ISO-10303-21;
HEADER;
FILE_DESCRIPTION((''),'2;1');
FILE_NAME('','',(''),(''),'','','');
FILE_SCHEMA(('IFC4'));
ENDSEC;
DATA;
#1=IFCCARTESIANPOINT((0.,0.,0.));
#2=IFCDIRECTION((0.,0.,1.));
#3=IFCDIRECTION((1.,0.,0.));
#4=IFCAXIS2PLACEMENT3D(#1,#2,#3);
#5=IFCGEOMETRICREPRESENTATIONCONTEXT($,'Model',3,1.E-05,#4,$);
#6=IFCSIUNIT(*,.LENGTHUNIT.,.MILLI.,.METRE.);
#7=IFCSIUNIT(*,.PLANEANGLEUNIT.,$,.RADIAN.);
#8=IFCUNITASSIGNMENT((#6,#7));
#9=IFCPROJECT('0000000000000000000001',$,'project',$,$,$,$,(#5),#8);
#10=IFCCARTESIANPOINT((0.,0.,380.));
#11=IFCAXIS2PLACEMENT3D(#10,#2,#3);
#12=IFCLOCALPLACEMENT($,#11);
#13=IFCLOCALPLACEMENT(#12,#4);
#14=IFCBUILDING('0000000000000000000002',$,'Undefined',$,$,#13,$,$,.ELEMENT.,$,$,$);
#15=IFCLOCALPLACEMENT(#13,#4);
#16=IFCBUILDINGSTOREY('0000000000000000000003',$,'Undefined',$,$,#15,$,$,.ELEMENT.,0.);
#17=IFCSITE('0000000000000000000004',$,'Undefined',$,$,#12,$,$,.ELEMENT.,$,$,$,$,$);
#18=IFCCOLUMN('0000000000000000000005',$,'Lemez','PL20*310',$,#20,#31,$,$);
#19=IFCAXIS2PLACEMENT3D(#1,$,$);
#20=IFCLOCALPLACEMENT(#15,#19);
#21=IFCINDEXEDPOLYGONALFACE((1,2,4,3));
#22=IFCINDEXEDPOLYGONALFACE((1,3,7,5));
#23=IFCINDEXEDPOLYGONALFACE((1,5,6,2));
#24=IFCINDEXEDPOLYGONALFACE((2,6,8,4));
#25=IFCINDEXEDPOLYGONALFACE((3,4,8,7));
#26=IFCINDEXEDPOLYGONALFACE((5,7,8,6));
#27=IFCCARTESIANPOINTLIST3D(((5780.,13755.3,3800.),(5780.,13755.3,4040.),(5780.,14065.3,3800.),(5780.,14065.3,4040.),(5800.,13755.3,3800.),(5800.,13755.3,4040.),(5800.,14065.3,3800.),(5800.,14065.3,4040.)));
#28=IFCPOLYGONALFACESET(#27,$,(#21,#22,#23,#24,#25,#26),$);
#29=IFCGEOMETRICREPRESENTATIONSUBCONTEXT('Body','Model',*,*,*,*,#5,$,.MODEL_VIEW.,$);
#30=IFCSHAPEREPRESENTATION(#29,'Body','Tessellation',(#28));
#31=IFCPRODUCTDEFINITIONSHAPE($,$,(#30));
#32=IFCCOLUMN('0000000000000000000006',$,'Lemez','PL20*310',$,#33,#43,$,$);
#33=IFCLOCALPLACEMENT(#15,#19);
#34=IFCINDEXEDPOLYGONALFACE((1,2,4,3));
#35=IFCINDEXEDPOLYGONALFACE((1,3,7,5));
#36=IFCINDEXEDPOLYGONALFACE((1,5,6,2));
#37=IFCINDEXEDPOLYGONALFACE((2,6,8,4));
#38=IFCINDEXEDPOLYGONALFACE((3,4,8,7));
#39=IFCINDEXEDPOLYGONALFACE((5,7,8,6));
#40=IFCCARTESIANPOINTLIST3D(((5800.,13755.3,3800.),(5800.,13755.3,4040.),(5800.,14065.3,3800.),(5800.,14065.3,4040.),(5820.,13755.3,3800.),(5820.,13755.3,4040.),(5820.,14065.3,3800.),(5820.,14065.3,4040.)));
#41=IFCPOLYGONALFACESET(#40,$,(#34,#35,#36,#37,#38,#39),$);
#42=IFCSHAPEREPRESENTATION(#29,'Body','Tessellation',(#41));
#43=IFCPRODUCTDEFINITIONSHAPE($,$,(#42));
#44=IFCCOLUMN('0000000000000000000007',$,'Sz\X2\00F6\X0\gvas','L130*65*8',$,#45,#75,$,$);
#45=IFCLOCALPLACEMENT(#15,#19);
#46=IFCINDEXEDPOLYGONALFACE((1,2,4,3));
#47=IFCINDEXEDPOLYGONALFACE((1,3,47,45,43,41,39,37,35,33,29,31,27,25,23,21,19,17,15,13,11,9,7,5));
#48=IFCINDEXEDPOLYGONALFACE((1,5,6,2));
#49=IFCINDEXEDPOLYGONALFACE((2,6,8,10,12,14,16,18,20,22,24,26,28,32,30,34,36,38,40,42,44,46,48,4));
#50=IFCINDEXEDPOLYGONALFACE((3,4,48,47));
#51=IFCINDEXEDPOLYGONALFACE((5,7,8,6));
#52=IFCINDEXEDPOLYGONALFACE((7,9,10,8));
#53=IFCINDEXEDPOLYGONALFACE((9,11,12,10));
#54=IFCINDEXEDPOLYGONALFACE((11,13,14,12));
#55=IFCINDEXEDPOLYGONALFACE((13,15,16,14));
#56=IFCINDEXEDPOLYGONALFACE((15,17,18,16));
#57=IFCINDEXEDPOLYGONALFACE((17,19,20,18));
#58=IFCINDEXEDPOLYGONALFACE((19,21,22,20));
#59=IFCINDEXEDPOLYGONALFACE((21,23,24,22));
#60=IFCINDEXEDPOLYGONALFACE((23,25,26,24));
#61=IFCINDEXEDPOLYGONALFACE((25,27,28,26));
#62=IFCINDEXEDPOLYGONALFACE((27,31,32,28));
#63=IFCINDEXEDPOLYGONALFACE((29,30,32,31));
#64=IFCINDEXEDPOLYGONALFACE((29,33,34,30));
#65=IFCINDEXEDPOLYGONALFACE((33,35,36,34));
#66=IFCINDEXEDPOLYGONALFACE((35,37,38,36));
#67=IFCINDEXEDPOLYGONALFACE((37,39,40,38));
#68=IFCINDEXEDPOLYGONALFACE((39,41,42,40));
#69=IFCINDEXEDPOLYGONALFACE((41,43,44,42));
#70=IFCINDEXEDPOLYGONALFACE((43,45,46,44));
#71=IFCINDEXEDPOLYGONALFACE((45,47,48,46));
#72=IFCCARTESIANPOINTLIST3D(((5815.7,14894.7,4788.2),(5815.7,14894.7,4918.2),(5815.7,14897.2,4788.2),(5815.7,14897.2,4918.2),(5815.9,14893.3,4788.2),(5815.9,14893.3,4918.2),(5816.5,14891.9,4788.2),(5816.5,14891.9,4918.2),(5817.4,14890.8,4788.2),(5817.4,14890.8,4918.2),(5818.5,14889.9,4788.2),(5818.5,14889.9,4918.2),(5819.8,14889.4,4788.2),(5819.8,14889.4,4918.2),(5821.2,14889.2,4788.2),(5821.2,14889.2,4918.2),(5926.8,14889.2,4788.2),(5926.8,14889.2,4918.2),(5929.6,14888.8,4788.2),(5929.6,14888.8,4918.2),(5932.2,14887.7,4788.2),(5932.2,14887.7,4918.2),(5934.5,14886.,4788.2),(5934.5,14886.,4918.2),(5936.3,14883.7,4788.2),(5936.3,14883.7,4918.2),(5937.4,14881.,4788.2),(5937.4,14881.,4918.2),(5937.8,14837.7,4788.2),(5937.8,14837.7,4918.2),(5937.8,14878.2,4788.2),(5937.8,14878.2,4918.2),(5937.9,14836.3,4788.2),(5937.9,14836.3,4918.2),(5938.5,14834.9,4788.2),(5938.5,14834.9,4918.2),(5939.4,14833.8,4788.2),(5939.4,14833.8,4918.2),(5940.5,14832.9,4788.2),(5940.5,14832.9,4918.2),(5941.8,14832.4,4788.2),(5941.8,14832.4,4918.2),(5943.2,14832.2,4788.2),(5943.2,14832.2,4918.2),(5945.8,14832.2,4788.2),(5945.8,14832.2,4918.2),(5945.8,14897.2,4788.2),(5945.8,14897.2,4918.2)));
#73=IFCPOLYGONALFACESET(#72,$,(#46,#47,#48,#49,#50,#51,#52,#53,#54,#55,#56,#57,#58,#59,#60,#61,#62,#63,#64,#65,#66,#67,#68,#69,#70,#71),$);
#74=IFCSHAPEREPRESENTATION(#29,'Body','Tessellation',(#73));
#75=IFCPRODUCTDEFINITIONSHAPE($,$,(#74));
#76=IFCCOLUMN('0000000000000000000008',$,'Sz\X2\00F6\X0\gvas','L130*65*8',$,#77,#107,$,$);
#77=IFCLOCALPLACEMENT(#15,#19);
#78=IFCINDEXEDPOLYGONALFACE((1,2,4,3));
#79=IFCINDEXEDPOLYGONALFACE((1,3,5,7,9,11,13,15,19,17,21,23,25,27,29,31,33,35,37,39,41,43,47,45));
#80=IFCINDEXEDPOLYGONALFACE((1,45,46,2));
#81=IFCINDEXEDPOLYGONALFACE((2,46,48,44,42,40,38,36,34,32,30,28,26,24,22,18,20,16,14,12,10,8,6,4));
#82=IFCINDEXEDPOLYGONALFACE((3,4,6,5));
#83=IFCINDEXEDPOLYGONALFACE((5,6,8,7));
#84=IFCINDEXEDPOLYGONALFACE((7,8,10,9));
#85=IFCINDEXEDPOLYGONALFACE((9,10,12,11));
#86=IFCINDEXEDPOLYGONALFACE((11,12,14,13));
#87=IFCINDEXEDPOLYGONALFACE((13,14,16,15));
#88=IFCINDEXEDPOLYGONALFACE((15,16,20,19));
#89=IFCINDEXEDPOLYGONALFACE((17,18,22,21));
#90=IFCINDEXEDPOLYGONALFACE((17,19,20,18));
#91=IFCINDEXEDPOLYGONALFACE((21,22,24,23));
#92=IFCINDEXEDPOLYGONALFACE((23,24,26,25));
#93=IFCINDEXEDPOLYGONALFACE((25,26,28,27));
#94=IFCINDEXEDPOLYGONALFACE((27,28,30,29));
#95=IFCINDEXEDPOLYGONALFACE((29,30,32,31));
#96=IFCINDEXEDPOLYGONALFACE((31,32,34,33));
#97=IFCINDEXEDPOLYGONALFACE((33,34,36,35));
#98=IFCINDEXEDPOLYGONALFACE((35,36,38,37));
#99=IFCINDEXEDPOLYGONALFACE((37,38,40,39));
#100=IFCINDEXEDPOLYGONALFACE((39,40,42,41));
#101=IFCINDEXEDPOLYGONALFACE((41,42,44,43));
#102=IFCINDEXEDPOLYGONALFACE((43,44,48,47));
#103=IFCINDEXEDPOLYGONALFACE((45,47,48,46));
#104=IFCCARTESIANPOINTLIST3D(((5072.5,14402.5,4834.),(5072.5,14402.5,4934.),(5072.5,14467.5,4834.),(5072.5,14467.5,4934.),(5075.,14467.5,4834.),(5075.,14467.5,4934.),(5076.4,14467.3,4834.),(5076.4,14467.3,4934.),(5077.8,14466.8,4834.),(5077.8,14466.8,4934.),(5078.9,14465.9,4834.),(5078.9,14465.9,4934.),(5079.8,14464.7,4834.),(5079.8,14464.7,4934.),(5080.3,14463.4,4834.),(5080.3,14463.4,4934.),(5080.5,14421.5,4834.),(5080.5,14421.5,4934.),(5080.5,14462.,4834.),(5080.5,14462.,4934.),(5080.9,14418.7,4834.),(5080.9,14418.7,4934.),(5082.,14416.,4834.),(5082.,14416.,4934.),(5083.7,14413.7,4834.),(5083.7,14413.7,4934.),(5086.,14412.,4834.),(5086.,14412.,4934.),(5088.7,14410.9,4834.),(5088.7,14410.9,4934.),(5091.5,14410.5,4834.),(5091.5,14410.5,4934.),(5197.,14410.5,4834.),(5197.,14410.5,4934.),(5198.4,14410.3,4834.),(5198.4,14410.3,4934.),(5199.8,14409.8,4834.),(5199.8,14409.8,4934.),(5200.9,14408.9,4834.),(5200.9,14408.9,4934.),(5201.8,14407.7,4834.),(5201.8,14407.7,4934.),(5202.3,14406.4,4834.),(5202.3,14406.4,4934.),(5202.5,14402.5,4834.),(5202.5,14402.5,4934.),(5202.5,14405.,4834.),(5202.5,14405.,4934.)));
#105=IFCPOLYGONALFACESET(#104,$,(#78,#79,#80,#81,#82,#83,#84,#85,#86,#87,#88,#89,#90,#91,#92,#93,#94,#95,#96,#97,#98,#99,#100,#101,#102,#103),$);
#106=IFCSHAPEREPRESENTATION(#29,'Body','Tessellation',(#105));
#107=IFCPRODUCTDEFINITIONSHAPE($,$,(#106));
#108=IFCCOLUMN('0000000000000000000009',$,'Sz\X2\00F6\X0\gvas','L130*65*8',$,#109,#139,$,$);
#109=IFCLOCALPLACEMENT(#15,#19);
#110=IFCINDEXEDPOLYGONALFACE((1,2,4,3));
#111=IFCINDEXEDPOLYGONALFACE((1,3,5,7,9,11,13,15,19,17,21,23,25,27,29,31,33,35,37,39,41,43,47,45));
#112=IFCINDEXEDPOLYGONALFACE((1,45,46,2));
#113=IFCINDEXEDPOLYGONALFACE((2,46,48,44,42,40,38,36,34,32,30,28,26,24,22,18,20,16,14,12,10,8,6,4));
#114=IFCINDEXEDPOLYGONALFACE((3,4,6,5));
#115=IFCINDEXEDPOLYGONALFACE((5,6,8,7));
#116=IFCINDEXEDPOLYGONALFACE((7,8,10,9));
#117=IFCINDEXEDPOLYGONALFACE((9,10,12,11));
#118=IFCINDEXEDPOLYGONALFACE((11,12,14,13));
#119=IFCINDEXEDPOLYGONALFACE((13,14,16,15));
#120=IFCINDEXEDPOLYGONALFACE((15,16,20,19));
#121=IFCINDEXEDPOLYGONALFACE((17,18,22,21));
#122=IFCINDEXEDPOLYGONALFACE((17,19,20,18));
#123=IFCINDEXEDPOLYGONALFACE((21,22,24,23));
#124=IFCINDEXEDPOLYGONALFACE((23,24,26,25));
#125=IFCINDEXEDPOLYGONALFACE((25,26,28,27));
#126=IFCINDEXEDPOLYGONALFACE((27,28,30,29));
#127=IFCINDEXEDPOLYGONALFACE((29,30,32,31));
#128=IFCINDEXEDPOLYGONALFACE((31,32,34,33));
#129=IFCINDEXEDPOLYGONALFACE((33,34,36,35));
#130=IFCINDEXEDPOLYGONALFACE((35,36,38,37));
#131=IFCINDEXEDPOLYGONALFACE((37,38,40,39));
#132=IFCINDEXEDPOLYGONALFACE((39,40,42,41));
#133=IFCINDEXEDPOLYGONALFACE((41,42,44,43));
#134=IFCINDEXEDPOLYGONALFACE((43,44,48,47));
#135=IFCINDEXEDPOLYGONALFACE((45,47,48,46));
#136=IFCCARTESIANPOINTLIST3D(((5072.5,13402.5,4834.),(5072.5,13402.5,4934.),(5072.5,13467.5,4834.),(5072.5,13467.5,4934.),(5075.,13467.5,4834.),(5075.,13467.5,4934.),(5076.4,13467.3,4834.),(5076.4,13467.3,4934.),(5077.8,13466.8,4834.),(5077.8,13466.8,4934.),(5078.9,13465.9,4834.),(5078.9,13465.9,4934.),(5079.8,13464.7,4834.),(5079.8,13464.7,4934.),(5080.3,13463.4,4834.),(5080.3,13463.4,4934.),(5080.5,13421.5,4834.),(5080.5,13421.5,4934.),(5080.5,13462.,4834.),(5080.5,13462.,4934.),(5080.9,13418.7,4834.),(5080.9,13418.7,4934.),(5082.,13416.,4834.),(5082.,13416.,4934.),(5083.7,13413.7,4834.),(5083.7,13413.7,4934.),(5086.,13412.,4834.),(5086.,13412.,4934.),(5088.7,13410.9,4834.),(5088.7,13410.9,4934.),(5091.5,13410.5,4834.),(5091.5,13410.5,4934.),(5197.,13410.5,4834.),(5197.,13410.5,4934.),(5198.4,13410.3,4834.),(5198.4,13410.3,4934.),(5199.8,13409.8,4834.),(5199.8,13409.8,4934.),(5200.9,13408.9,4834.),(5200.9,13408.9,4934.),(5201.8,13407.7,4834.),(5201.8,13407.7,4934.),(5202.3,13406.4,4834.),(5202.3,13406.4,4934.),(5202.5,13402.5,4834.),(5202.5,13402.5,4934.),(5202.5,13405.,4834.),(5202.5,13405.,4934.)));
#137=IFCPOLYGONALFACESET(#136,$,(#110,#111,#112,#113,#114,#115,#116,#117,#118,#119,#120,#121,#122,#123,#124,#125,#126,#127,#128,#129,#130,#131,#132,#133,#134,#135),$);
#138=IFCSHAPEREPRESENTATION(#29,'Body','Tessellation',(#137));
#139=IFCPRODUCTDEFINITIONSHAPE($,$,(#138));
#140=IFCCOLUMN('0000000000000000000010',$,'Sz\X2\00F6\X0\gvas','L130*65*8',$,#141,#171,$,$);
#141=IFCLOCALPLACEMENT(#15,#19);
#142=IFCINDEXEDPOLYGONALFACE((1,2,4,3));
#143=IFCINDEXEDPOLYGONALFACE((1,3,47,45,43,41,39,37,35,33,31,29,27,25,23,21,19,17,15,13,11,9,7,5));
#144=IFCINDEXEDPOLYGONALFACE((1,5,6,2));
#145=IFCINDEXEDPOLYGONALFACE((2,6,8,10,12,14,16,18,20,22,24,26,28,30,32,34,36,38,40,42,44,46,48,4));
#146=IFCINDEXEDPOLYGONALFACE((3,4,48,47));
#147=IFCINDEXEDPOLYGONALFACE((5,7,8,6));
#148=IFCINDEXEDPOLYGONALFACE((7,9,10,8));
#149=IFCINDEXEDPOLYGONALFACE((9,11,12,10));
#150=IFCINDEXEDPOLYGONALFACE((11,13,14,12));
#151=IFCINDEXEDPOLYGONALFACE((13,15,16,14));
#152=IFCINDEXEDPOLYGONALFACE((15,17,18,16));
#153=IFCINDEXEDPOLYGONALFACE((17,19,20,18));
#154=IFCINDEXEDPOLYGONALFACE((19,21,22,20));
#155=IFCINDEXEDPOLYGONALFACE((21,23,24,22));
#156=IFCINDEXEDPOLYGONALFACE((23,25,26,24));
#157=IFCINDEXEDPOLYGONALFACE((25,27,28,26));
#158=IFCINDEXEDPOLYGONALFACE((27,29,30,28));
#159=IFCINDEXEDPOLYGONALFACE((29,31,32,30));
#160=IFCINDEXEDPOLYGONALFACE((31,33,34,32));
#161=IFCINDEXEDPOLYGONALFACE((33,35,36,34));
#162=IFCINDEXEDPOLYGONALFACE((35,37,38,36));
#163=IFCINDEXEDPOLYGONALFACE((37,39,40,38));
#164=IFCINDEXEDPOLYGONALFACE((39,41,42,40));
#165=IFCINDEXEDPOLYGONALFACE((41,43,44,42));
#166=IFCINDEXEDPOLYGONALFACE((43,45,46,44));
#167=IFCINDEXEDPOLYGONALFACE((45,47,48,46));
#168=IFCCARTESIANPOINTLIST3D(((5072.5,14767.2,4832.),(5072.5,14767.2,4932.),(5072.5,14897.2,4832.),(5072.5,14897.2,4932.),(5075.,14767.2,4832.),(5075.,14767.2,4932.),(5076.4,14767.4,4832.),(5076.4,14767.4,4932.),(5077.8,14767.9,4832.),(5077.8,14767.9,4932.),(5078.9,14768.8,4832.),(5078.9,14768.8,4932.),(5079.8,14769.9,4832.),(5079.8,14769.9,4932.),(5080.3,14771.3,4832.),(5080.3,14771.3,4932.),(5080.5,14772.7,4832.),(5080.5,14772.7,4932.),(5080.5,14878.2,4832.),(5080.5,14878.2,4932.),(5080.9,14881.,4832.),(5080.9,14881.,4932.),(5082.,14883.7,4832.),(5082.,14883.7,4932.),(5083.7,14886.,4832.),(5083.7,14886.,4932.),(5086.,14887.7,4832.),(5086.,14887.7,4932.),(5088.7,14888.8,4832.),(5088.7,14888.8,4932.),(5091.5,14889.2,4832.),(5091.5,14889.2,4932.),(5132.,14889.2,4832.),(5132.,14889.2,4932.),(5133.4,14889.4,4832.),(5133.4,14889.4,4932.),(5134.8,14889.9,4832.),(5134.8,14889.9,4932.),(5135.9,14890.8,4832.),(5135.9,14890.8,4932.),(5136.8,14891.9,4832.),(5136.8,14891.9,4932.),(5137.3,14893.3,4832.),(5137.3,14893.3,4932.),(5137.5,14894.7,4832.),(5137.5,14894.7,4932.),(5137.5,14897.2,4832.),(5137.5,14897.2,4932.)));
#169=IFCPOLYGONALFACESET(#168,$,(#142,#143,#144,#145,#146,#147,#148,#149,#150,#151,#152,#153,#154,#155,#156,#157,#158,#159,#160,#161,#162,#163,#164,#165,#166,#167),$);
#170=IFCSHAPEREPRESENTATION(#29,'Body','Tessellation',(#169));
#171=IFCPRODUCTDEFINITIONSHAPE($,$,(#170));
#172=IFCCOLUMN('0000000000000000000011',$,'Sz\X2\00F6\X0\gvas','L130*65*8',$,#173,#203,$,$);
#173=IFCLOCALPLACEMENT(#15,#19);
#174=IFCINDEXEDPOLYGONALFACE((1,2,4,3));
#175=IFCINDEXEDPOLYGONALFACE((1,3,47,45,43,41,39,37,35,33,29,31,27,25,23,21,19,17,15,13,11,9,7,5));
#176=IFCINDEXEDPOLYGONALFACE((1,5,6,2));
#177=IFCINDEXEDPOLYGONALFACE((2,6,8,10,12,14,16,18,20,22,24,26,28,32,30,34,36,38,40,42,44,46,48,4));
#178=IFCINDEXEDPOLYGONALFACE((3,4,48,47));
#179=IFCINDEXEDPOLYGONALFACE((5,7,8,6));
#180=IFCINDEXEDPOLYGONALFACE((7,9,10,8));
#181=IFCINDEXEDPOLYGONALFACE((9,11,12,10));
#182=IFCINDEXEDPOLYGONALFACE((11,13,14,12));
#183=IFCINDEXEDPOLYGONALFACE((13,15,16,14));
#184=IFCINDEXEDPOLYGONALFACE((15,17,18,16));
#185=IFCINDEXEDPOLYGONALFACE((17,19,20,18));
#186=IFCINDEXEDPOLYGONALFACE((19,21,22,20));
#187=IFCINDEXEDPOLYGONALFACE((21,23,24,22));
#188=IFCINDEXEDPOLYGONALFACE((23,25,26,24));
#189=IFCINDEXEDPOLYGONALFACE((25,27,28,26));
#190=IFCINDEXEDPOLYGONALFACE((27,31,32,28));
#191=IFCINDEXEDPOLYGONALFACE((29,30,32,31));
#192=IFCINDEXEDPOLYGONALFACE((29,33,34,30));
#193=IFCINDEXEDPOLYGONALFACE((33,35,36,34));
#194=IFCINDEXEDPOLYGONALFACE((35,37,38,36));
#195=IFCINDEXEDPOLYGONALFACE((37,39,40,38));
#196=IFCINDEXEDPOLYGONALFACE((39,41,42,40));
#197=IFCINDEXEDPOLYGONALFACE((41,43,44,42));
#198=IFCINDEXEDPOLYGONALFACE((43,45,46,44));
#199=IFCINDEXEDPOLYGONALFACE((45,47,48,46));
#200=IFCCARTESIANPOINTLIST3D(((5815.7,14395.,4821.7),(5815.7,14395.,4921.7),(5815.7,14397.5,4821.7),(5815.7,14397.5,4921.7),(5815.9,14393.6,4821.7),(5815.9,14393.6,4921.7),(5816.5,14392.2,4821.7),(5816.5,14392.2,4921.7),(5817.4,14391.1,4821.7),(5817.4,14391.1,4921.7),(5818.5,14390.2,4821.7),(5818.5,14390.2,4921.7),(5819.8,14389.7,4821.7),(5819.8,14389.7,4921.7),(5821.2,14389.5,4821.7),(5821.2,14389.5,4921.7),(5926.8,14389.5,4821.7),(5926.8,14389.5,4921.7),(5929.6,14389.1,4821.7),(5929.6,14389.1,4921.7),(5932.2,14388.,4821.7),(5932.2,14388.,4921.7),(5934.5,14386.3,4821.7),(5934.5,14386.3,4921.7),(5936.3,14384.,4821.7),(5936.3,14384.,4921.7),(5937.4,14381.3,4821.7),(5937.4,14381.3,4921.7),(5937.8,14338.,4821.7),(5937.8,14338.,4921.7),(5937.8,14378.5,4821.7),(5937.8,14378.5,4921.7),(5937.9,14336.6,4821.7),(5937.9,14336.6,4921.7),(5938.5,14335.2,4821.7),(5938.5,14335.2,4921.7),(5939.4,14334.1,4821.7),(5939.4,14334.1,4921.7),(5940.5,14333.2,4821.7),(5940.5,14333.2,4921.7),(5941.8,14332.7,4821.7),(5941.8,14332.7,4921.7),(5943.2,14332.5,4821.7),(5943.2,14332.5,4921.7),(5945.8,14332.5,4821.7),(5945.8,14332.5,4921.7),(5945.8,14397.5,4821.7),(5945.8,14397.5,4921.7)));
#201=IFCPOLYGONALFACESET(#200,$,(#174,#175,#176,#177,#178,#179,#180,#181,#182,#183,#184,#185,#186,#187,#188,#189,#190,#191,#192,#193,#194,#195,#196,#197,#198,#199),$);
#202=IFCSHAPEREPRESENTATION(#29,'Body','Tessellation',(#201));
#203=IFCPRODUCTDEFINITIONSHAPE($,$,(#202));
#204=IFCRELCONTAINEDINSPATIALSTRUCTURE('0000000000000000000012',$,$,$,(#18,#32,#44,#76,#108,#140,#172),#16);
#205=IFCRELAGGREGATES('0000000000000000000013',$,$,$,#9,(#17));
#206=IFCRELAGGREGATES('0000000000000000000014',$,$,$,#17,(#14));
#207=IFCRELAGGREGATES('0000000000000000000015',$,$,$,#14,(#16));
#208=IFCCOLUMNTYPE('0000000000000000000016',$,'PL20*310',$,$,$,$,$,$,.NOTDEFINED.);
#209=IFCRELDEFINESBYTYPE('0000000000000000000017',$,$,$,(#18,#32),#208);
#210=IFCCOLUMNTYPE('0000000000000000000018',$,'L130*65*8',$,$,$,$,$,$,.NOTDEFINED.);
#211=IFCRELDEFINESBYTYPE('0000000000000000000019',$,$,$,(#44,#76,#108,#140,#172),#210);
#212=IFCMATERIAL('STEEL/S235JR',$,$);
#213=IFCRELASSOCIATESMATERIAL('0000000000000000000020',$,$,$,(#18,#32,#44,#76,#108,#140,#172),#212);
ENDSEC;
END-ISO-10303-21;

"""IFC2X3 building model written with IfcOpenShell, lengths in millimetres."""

from ifc_helpers import new_model, si_unit, frame, origin_with_axes, origin_2d_with_axis, place, context, subcontext, project, spatial, rectangle, l_section, extrude, material, type_object, element, save


model = new_model("IFC2X3")

# Units and contexts
model_context = context("Model", 3, precision=1e-05, world=origin_with_axes())
body_context = subcontext(model_context, "Body", "Model", "MODEL_VIEW")
ifc_project = project(units=[si_unit("LENGTHUNIT", "METRE", prefix="MILLI"), si_unit("PLANEANGLEUNIT", "RADIAN")], contexts=[model_context])

# Site, building, storey
site_placement = place(None, frame((0.0, 0.0, 380.0), z_axis=(0.0, 0.0, 1.0), x_axis=(1.0, 0.0, 0.0)))
site = spatial("IfcSite", under=ifc_project, at=site_placement, Name="Undefined", CompositionType="ELEMENT")
building_placement = place(site_placement, origin_with_axes())
building = spatial("IfcBuilding", under=site, at=building_placement, Name="Undefined", CompositionType="ELEMENT")
storey_placement = place(building_placement, origin_with_axes())
storey = spatial("IfcBuildingStorey", under=building, at=storey_placement, Name="Undefined", CompositionType="ELEMENT", Elevation=0.0)

# Columns
ifc_material_1 = material(Name="STEEL/S235JR")
column_type_1 = type_object("IfcColumnType", Name="PL20*310", PredefinedType="NOTDEFINED")
for number, where, z_axis, x_axis, name in (
    (1, (5790.0, 13910.3, 3800.0), (0.0, 0.0, 1.0), (0.0, 1.0, 0.0), "Lemez"),
    (2, (5810.0, 13910.3, 3800.0), (0.0, 0.0, 1.0), (0.0, 1.0, 0.0), "Lemez"),
):
    element("IfcColumn", number, at=place(storey_placement, frame(where, z_axis=z_axis, x_axis=x_axis)), inside=storey, type_object=column_type_1, material=ifc_material_1, Name=name, Description="PL20*310", context=body_context, shape_type="SweptSolid", body=[
        extrude(rectangle(XDim=20.0, YDim=310.0, at=origin_2d_with_axis()), frame((0.0, 0.0, 240.0), z_axis=(0.0, 0.0, -1.0), x_axis=(0.0, 1.0, 0.0)), (0.0, 0.0, 1.0), 240.0),
    ])
column_type_2 = type_object("IfcColumnType", Name="L130*65*8", PredefinedType="NOTDEFINED")
column_placement = place(storey_placement, frame((5880.8, 14864.7, 4788.2), z_axis=(0.0, 0.0, 1.0), x_axis=(-1.0, 0.0, 0.0)))
element("IfcColumn", 3, at=column_placement, inside=storey, type_object=column_type_2, material=ifc_material_1, Name="Szögvas", Description="L130*65*8", context=body_context, shape_type="SweptSolid", body=[
    extrude(l_section(Depth=130.0, Width=65.0, Thickness=8.0, FilletRadius=11.0, EdgeRadius=5.5, at=origin_2d_with_axis()), frame((0.0, 0.0, 130.0), z_axis=(0.0, 0.0, -1.0), x_axis=(0.0, 1.0, 0.0)), (0.0, 0.0, 1.0), 130.0),
])
for number, where, z_axis, x_axis, name in (
    (4, (5137.5, 14435.0, 4834.0), (0.0, 0.0, 1.0), (1.0, 0.0, 0.0), "Szögvas"),
    (5, (5137.5, 13435.0, 4834.0), (0.0, 0.0, 1.0), (1.0, 0.0, 0.0), "Szögvas"),
    (6, (5105.0, 14832.2, 4832.0), (0.0, 0.0, 1.0), (0.0, -1.0, 0.0), "Szögvas"),
    (7, (5880.8, 14365.0, 4821.7), (0.0, 0.0, 1.0), (-1.0, 0.0, 0.0), "Szögvas"),
):
    element("IfcColumn", number, at=place(storey_placement, frame(where, z_axis=z_axis, x_axis=x_axis)), inside=storey, type_object=column_type_2, material=ifc_material_1, Name=name, Description="L130*65*8", context=body_context, shape_type="SweptSolid", body=[
        extrude(l_section(Depth=130.0, Width=65.0, Thickness=8.0, FilletRadius=11.0, EdgeRadius=5.5, at=origin_2d_with_axis()), frame((0.0, 0.0, 100.0), z_axis=(0.0, 0.0, -1.0), x_axis=(0.0, 1.0, 0.0)), (0.0, 0.0, 1.0), 100.0),
    ])

save(model, "model.ifc")
